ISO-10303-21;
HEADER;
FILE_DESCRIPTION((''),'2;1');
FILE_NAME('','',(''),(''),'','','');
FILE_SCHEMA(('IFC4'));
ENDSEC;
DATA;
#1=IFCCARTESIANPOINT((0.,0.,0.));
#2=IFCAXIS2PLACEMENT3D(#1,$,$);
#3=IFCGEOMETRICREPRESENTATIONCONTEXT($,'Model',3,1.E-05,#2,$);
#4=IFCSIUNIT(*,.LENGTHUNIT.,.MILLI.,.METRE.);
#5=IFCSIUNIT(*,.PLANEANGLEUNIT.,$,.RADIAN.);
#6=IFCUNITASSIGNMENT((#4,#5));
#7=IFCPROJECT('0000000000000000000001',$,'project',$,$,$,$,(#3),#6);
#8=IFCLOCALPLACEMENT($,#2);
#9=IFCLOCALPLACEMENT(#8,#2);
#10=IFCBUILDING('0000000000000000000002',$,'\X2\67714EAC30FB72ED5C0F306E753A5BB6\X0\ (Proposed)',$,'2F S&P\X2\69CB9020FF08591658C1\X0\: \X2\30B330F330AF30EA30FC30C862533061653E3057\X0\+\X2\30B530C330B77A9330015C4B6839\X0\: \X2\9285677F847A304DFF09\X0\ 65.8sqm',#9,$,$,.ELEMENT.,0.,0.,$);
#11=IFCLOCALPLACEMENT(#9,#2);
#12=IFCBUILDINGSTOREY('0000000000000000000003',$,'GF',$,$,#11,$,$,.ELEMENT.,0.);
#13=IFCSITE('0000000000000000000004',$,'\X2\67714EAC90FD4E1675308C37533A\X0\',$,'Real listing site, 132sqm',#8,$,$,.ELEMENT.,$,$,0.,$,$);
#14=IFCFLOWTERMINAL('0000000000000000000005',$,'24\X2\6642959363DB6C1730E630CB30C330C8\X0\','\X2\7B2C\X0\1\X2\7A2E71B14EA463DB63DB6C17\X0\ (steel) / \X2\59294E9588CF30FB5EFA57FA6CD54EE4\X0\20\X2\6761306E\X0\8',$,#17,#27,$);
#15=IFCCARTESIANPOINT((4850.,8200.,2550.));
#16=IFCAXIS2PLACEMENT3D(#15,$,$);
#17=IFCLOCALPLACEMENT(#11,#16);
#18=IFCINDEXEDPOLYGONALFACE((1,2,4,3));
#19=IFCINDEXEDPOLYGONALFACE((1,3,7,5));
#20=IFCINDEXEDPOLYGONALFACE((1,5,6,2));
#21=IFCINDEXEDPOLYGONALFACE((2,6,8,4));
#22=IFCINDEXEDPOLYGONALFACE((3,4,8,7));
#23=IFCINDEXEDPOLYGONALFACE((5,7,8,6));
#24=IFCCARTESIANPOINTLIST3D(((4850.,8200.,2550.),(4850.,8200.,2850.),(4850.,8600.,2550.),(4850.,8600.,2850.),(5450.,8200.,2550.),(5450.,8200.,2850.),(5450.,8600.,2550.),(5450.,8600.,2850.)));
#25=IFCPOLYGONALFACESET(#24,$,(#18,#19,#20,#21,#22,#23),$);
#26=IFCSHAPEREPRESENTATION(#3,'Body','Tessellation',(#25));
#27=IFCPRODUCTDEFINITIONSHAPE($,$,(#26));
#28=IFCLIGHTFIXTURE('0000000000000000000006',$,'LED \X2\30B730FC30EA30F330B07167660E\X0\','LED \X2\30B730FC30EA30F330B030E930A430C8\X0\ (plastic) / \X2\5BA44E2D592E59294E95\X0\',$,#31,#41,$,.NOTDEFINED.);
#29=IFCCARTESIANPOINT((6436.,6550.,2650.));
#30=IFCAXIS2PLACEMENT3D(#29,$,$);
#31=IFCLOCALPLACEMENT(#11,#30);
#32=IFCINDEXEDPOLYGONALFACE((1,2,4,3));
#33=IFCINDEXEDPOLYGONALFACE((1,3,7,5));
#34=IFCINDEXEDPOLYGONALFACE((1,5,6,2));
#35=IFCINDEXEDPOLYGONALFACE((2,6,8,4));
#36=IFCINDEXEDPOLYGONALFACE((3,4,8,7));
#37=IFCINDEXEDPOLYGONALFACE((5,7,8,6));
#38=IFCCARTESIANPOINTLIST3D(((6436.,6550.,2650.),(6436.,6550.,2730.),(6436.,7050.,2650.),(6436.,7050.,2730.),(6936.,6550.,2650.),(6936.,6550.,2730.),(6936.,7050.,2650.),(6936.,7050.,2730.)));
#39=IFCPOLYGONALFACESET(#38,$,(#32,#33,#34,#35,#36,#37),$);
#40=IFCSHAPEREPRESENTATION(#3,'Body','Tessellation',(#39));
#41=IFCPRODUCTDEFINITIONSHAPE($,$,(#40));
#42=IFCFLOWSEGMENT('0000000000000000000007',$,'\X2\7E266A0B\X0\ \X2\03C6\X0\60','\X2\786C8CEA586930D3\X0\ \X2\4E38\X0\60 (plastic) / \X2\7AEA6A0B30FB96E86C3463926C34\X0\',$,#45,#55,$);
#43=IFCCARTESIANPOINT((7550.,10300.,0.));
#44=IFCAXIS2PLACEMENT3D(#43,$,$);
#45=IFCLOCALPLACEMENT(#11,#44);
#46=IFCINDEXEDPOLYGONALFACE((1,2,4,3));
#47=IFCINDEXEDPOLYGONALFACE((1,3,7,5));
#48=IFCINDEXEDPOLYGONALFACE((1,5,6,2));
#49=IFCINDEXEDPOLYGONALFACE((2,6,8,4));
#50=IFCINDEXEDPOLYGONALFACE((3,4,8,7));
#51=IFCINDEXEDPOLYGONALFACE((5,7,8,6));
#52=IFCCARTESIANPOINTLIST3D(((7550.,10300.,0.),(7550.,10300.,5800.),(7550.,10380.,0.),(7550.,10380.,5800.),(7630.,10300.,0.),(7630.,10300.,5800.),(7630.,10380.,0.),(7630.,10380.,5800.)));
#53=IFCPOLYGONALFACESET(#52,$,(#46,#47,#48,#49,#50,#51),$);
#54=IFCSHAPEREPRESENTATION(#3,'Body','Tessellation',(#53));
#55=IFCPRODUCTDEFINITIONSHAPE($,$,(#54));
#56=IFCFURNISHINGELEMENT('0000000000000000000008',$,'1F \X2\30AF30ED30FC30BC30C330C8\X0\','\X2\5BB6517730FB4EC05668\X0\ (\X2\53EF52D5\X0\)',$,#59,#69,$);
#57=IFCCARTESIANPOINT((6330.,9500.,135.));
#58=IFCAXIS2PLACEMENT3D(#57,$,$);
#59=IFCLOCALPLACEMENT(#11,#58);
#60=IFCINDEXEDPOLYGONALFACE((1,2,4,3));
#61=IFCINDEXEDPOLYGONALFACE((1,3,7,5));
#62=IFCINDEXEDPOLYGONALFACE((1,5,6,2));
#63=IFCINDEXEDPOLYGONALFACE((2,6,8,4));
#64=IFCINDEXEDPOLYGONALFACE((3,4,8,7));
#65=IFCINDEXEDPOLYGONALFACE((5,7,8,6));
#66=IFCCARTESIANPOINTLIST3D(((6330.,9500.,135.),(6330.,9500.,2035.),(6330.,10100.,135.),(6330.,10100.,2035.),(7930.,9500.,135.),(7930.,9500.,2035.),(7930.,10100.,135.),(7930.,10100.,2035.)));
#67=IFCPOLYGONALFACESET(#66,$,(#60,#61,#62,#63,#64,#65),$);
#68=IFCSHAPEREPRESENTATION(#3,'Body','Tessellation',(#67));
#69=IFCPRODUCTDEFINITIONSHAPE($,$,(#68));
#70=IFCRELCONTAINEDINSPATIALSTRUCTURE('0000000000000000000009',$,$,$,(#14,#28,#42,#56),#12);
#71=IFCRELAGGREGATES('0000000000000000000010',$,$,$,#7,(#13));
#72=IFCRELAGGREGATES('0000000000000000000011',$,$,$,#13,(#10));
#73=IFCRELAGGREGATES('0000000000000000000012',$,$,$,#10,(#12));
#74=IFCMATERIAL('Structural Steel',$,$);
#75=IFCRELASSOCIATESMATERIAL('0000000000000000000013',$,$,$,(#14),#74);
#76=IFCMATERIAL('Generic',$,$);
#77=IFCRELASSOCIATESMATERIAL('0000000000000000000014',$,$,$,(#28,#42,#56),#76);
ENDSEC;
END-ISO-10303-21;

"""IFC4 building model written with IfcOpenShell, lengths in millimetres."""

from ifc_helpers import new_model, si_unit, frame, frame_2d, origin, place, context, project, spatial, rectangle, extrude, material, element, save


model = new_model("IFC4")

# Units and contexts
model_context = context("Model", 3, precision=1e-05, world=origin())
ifc_project = project(units=[si_unit("LENGTHUNIT", "METRE", prefix="MILLI"), si_unit("PLANEANGLEUNIT", "RADIAN")], contexts=[model_context])

# Site, building, storey
site_placement = place(None, origin())
site = spatial("IfcSite", under=ifc_project, at=site_placement, Name="東京都世田谷区", ObjectType="Real listing site, 132sqm", CompositionType="ELEMENT", RefElevation=0.0)
building_placement = place(site_placement, origin())
building = spatial("IfcBuilding", under=site, at=building_placement, Name="東京・狭小の町家 (Proposed)", ObjectType="2F S&P構造（外壁: コンクリート打ち放し+サッシ窓、屋根: 銅板葺き） 65.8sqm", CompositionType="ELEMENT", ElevationOfRefHeight=0.0, ElevationOfTerrain=0.0)
storey_placement = place(building_placement, origin())
storey = spatial("IfcBuildingStorey", under=building, at=storey_placement, Name="GF", CompositionType="ELEMENT", Elevation=0.0)

# Shared definitions
ifc_material_1 = material(Name="Generic")

# Flow terminal
ifc_material_2 = material(Name="Structural Steel")
flow_terminal_placement = place(storey_placement, frame((4850.0, 8200.0, 2550.0)))
element("IfcFlowTerminal", 1, at=flow_terminal_placement, inside=storey, material=ifc_material_2, Name="24時間換気ユニット", Description="第1種熱交換換気 (steel) / 天井裏・建基法令20条の8", context=model_context, shape_type="SweptSolid", body=[
    extrude(rectangle(XDim=600.0, YDim=400.0, at=frame_2d((300.0, 200.0))), frame((4850.0, 8200.0, 2550.0)), (0.0, 0.0, 1.0), 300.0),
])

# Light fixture
light_fixture_placement = place(storey_placement, frame((6436.0, 6550.0, 2650.0)))
element("IfcLightFixture", 2, at=light_fixture_placement, inside=storey, material=ifc_material_1, Name="LED シーリング照明", Description="LED シーリングライト (plastic) / 室中央天井", PredefinedType="NOTDEFINED", context=model_context, shape_type="SweptSolid", body=[
    extrude(rectangle(XDim=500.0, YDim=500.0, at=frame_2d((250.0, 250.0))), frame((6436.0, 6550.0, 2650.0)), (0.0, 0.0, 1.0), 80.0),
])

# Flow segment
flow_segment_placement = place(storey_placement, frame((7550.0, 10300.0, 0.0)))
element("IfcFlowSegment", 3, at=flow_segment_placement, inside=storey, material=ifc_material_1, Name="縦樋 φ60", Description="硬質塩ビ 丸60 (plastic) / 竪樋・雨水排水", context=model_context, shape_type="SweptSolid", body=[
    extrude(rectangle(XDim=80.0, YDim=80.0, at=frame_2d((40.0, 40.0))), frame((7550.0, 10300.0, 0.0)), (0.0, 0.0, 1.0), 5800.0),
])

# Furnishing element
furnishing_placement = place(storey_placement, frame((6330.0, 9500.0, 135.0)))
element("IfcFurnishingElement", 4, at=furnishing_placement, inside=storey, material=ifc_material_1, Name="1F クローゼット", Description="家具・什器 (可動)", context=model_context, shape_type="SweptSolid", body=[
    extrude(rectangle(XDim=1600.0, YDim=600.0, at=frame_2d((800.0, 300.0))), frame((6330.0, 9500.0, 135.0)), (0.0, 0.0, 1.0), 1900.0),
])

save(model, "model.ifc")
